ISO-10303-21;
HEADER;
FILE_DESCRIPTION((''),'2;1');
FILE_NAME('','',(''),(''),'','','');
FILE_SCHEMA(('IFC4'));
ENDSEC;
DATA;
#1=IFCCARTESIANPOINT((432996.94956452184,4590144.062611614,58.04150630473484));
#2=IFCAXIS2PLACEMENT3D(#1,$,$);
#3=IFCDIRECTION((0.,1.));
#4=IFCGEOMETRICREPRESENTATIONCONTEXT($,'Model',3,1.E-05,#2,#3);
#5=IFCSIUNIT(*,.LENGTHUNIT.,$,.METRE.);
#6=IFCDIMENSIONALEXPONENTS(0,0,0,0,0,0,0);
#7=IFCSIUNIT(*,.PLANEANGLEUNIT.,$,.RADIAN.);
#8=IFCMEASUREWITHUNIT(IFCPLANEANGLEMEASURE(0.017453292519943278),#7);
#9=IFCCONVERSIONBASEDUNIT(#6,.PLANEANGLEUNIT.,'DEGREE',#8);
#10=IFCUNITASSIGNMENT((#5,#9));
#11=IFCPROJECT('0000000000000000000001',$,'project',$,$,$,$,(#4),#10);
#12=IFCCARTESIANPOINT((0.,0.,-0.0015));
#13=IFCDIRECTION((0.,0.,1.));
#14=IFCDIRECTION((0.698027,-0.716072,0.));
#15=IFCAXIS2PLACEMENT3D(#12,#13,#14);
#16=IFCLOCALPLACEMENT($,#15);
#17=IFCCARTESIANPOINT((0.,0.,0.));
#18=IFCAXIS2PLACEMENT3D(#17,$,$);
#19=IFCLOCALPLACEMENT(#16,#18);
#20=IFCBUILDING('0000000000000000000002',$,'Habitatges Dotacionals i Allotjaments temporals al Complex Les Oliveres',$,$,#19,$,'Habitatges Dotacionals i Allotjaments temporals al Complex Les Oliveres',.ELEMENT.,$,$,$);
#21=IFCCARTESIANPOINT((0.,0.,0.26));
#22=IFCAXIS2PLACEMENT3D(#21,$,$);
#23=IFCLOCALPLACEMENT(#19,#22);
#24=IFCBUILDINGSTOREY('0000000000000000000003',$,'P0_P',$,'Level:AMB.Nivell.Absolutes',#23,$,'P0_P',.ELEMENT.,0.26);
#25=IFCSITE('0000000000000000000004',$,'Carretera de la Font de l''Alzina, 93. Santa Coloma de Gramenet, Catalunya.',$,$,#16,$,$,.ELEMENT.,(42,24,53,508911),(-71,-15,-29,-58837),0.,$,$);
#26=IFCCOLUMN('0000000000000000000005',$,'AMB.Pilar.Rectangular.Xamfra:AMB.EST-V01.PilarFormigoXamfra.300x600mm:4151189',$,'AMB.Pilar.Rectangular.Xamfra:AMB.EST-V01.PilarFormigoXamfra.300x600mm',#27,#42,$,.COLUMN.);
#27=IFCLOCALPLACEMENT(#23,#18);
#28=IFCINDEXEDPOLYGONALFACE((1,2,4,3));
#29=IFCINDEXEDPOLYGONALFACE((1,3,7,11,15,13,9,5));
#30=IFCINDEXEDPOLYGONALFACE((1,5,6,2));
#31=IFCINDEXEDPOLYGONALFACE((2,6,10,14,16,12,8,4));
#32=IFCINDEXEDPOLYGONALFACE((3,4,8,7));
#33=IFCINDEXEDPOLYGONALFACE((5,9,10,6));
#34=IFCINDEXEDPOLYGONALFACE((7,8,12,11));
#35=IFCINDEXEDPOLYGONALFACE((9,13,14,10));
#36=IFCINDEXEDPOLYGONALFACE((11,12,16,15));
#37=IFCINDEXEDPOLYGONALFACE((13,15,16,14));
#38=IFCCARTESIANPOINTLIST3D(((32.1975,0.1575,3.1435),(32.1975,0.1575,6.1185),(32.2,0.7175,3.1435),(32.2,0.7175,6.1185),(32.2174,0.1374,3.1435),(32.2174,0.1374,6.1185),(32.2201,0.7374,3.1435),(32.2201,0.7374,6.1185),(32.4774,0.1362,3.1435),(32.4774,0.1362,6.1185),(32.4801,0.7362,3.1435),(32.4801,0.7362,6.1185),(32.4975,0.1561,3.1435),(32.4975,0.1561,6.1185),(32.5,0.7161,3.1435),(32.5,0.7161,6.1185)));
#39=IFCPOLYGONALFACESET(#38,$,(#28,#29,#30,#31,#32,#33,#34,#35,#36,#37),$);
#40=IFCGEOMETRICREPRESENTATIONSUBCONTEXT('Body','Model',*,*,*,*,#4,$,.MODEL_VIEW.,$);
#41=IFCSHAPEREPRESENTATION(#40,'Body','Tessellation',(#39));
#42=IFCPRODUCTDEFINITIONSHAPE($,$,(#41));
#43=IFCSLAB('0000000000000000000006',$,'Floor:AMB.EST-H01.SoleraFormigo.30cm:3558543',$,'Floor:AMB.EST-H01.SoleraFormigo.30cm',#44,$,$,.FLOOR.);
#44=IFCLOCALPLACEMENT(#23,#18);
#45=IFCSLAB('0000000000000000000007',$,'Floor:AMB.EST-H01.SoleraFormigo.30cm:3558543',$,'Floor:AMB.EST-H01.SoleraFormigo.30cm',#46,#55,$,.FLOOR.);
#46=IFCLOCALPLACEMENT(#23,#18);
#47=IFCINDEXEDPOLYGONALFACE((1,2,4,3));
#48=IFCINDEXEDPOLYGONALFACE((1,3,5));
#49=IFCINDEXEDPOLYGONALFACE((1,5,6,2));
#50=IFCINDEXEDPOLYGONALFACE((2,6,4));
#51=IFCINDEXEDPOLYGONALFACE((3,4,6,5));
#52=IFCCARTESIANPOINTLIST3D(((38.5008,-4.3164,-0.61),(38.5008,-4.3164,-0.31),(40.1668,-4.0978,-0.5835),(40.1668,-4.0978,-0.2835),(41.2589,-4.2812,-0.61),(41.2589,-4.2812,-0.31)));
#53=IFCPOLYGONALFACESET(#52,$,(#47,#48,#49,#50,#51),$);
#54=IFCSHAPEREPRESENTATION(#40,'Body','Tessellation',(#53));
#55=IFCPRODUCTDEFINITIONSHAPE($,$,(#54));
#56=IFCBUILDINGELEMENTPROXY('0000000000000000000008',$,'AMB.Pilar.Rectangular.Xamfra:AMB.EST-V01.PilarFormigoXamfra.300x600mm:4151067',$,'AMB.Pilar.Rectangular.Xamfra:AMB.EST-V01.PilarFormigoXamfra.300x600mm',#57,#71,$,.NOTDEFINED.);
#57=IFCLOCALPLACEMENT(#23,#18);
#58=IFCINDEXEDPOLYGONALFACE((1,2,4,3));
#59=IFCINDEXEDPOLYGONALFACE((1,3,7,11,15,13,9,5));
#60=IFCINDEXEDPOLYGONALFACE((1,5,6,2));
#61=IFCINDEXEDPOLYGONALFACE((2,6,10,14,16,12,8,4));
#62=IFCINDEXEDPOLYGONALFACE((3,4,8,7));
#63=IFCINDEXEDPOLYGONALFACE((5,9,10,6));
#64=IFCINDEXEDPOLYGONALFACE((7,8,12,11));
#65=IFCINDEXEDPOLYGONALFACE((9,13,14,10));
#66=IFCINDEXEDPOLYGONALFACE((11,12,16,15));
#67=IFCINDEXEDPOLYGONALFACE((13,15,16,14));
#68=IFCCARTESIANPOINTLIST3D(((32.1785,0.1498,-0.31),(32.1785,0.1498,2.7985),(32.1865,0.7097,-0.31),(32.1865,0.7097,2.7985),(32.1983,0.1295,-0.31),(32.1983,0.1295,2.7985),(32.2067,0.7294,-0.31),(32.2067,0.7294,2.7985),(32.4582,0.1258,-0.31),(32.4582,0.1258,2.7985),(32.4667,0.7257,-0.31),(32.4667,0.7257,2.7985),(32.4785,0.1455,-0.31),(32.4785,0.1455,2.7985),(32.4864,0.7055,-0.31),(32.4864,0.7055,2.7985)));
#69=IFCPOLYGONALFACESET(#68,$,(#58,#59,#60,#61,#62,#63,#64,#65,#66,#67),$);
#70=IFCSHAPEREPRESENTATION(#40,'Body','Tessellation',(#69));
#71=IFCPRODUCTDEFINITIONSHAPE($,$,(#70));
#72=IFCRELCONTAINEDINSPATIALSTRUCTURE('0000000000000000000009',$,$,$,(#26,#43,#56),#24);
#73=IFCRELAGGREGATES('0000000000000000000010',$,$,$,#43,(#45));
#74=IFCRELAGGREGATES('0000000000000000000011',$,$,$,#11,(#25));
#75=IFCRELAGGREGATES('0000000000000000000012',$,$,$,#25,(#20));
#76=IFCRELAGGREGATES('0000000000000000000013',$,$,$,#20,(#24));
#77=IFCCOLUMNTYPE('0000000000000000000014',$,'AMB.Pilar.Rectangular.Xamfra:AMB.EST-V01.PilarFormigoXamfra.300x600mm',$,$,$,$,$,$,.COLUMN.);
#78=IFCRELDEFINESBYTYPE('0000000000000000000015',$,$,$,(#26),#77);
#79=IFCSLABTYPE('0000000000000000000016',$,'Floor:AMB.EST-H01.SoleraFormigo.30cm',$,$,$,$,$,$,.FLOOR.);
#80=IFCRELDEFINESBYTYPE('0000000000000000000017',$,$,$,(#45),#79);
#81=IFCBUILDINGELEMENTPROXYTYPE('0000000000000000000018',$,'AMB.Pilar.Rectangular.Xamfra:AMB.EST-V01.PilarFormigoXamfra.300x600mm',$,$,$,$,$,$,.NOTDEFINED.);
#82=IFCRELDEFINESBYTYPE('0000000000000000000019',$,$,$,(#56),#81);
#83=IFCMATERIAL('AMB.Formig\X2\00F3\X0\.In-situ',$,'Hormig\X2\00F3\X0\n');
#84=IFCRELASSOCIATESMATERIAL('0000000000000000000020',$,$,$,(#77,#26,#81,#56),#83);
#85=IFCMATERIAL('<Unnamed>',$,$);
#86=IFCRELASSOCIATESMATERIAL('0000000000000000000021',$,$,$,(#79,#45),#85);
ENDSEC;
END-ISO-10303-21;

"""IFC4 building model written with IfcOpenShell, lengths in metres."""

from ifc_helpers import new_model, entity, si_unit, converted_unit, direction, frame, origin, place, context, subcontext, project, spatial, indexed_curve, outline, extrude, source, transform, mapped, material, type_object, type_shapes, element, aggregate, save


model = new_model("IFC4")

# Units and contexts
model_context = context("Model", 3, precision=1e-05, world=frame((432996.94956452184, 4590144.062611614, 58.04150630473484)), true_north=direction((0.0, 1.0)))
body_context = subcontext(model_context, "Body", "Model", "MODEL_VIEW")
ifc_project = project(units=[si_unit("LENGTHUNIT", "METRE"), converted_unit("PLANEANGLEUNIT", "DEGREE", entity("IfcPlaneAngleMeasure", 0.017453292519943278), si_unit("PLANEANGLEUNIT", "RADIAN"), dimensions=[0, 0, 0, 0, 0, 0, 0])], contexts=[model_context])

# Site, building, storey
site_placement = place(None, frame((0.0, 0.0, -0.0015), z_axis=(0.0, 0.0, 1.0), x_axis=(0.698027, -0.716072, 0.0)))
site = spatial("IfcSite", under=ifc_project, at=site_placement, Name="Carretera de la Font de l'Alzina, 93. Santa Coloma de Gramenet, Catalunya.", CompositionType="ELEMENT", RefLatitude=(42, 24, 53, 508911), RefLongitude=(-71, -15, -29, -58837), RefElevation=0.0)
building_placement = place(site_placement, origin())
building = spatial("IfcBuilding", under=site, at=building_placement, Name="Habitatges Dotacionals i Allotjaments temporals al Complex Les Oliveres", LongName="Habitatges Dotacionals i Allotjaments temporals al Complex Les Oliveres", CompositionType="ELEMENT")
storey_placement = place(building_placement, frame((0.0, 0.0, 0.26)))
storey = spatial("IfcBuildingStorey", under=building, at=storey_placement, Name="P0_P", ObjectType="Level:AMB.Nivell.Absolutes", LongName="P0_P", CompositionType="ELEMENT", Elevation=0.26)

# Column
ifc_material_1 = material(Name="AMB.Formigó.In-situ", Category="Hormigón")
column_type = type_object("IfcColumnType", Name="AMB.Pilar.Rectangular.Xamfra:AMB.EST-V01.PilarFormigoXamfra.300x600mm", PredefinedType="COLUMN", material=ifc_material_1)
shared_shape_1 = source(origin(), body_context, "Body", "SweptSolid", [
    extrude(outline(indexed_curve([(-0.13, -0.3), (0.13, -0.3), (0.15, -0.28), (0.15, 0.28), (0.13, 0.3), (-0.13, 0.3), (-0.15, 0.28), (-0.15, -0.28), (-0.13, -0.3)], self_intersect=False)), frame((0.0, 0.0, 3.4035), z_axis=(0.0, 0.0, 1.0), x_axis=(-1.0, 0.0, 0.0)), (0.0, 0.0, 1.0), 2.975),
])
type_shapes(column_type, [shared_shape_1])
column_placement = place(storey_placement, frame((32.3487, 0.4368, -0.26), z_axis=(0.0, 0.0, 1.0), x_axis=(0.99999, -0.004521, 0.0)))
element("IfcColumn", 1, at=column_placement, inside=storey, type_object=column_type, material=ifc_material_1, Name="AMB.Pilar.Rectangular.Xamfra:AMB.EST-V01.PilarFormigoXamfra.300x600mm:4151189", ObjectType="AMB.Pilar.Rectangular.Xamfra:AMB.EST-V01.PilarFormigoXamfra.300x600mm", PredefinedType="COLUMN", context=body_context, shape_type="MappedRepresentation", body=[
    mapped(shared_shape_1, transform((0.0, 0.0, 0.0), scale=1.0)),
])

# Slabs
slab_1_placement = place(storey_placement, frame((38.5008, -4.3164, -0.72)))
slab_1 = element("IfcSlab", 2, at=slab_1_placement, inside=storey, Name="Floor:AMB.EST-H01.SoleraFormigo.30cm:3558543", ObjectType="Floor:AMB.EST-H01.SoleraFormigo.30cm", PredefinedType="FLOOR")
ifc_material_2 = material(Name="<Unnamed>")
slab_type = type_object("IfcSlabType", Name="Floor:AMB.EST-H01.SoleraFormigo.30cm", PredefinedType="FLOOR", material=ifc_material_2)
slab_2_placement = place(slab_1_placement, origin())
slab_2 = element("IfcSlab", 3, at=slab_2_placement, type_object=slab_type, material=ifc_material_2, Name="Floor:AMB.EST-H01.SoleraFormigo.30cm:3558543", ObjectType="Floor:AMB.EST-H01.SoleraFormigo.30cm", PredefinedType="FLOOR", context=body_context, shape_type="SweptSolid", body=[
    extrude(outline(indexed_curve([(1.379, 0.0174), (0.287, 0.2027), (-1.379, -0.0174), (1.379, 0.0174)], self_intersect=False)), frame((1.379, 0.0176, 0.41), z_axis=(0.001696, -0.132888, 0.99113), x_axis=(0.999999, 0.000225, -0.001681)), (0.001681, -0.132889, -0.99113), 0.3),
])
aggregate(slab_1, [slab_2])

# Building element proxy
building_element_proxy_type = type_object("IfcBuildingElementProxyType", Name="AMB.Pilar.Rectangular.Xamfra:AMB.EST-V01.PilarFormigoXamfra.300x600mm", PredefinedType="NOTDEFINED", material=ifc_material_1)
shared_shape_2 = source(origin(), body_context, "Body", "SweptSolid", [
    extrude(outline(indexed_curve([(-0.13, -0.3), (0.13, -0.3), (0.15, -0.28), (0.15, 0.28), (0.13, 0.3), (-0.13, 0.3), (-0.15, 0.28), (-0.15, -0.28), (-0.13, -0.3)], self_intersect=False)), frame((0.0, 0.0, -0.05), z_axis=(0.0, 0.0, 1.0), x_axis=(-1.0, 0.0, 0.0)), (0.0, 0.0, 1.0), 3.1085),
])
type_shapes(building_element_proxy_type, [shared_shape_2])
proxy_placement = place(storey_placement, frame((32.3325, 0.4276, -0.26), z_axis=(0.0, 0.0, 1.0), x_axis=(0.9999, -0.014154, 0.0)))
element("IfcBuildingElementProxy", 4, at=proxy_placement, inside=storey, type_object=building_element_proxy_type, material=ifc_material_1, Name="AMB.Pilar.Rectangular.Xamfra:AMB.EST-V01.PilarFormigoXamfra.300x600mm:4151067", ObjectType="AMB.Pilar.Rectangular.Xamfra:AMB.EST-V01.PilarFormigoXamfra.300x600mm", PredefinedType="NOTDEFINED", context=body_context, shape_type="MappedRepresentation", body=[
    mapped(shared_shape_2, transform((0.0, 0.0, 0.0), scale=1.0)),
])

save(model, "model.ifc")
